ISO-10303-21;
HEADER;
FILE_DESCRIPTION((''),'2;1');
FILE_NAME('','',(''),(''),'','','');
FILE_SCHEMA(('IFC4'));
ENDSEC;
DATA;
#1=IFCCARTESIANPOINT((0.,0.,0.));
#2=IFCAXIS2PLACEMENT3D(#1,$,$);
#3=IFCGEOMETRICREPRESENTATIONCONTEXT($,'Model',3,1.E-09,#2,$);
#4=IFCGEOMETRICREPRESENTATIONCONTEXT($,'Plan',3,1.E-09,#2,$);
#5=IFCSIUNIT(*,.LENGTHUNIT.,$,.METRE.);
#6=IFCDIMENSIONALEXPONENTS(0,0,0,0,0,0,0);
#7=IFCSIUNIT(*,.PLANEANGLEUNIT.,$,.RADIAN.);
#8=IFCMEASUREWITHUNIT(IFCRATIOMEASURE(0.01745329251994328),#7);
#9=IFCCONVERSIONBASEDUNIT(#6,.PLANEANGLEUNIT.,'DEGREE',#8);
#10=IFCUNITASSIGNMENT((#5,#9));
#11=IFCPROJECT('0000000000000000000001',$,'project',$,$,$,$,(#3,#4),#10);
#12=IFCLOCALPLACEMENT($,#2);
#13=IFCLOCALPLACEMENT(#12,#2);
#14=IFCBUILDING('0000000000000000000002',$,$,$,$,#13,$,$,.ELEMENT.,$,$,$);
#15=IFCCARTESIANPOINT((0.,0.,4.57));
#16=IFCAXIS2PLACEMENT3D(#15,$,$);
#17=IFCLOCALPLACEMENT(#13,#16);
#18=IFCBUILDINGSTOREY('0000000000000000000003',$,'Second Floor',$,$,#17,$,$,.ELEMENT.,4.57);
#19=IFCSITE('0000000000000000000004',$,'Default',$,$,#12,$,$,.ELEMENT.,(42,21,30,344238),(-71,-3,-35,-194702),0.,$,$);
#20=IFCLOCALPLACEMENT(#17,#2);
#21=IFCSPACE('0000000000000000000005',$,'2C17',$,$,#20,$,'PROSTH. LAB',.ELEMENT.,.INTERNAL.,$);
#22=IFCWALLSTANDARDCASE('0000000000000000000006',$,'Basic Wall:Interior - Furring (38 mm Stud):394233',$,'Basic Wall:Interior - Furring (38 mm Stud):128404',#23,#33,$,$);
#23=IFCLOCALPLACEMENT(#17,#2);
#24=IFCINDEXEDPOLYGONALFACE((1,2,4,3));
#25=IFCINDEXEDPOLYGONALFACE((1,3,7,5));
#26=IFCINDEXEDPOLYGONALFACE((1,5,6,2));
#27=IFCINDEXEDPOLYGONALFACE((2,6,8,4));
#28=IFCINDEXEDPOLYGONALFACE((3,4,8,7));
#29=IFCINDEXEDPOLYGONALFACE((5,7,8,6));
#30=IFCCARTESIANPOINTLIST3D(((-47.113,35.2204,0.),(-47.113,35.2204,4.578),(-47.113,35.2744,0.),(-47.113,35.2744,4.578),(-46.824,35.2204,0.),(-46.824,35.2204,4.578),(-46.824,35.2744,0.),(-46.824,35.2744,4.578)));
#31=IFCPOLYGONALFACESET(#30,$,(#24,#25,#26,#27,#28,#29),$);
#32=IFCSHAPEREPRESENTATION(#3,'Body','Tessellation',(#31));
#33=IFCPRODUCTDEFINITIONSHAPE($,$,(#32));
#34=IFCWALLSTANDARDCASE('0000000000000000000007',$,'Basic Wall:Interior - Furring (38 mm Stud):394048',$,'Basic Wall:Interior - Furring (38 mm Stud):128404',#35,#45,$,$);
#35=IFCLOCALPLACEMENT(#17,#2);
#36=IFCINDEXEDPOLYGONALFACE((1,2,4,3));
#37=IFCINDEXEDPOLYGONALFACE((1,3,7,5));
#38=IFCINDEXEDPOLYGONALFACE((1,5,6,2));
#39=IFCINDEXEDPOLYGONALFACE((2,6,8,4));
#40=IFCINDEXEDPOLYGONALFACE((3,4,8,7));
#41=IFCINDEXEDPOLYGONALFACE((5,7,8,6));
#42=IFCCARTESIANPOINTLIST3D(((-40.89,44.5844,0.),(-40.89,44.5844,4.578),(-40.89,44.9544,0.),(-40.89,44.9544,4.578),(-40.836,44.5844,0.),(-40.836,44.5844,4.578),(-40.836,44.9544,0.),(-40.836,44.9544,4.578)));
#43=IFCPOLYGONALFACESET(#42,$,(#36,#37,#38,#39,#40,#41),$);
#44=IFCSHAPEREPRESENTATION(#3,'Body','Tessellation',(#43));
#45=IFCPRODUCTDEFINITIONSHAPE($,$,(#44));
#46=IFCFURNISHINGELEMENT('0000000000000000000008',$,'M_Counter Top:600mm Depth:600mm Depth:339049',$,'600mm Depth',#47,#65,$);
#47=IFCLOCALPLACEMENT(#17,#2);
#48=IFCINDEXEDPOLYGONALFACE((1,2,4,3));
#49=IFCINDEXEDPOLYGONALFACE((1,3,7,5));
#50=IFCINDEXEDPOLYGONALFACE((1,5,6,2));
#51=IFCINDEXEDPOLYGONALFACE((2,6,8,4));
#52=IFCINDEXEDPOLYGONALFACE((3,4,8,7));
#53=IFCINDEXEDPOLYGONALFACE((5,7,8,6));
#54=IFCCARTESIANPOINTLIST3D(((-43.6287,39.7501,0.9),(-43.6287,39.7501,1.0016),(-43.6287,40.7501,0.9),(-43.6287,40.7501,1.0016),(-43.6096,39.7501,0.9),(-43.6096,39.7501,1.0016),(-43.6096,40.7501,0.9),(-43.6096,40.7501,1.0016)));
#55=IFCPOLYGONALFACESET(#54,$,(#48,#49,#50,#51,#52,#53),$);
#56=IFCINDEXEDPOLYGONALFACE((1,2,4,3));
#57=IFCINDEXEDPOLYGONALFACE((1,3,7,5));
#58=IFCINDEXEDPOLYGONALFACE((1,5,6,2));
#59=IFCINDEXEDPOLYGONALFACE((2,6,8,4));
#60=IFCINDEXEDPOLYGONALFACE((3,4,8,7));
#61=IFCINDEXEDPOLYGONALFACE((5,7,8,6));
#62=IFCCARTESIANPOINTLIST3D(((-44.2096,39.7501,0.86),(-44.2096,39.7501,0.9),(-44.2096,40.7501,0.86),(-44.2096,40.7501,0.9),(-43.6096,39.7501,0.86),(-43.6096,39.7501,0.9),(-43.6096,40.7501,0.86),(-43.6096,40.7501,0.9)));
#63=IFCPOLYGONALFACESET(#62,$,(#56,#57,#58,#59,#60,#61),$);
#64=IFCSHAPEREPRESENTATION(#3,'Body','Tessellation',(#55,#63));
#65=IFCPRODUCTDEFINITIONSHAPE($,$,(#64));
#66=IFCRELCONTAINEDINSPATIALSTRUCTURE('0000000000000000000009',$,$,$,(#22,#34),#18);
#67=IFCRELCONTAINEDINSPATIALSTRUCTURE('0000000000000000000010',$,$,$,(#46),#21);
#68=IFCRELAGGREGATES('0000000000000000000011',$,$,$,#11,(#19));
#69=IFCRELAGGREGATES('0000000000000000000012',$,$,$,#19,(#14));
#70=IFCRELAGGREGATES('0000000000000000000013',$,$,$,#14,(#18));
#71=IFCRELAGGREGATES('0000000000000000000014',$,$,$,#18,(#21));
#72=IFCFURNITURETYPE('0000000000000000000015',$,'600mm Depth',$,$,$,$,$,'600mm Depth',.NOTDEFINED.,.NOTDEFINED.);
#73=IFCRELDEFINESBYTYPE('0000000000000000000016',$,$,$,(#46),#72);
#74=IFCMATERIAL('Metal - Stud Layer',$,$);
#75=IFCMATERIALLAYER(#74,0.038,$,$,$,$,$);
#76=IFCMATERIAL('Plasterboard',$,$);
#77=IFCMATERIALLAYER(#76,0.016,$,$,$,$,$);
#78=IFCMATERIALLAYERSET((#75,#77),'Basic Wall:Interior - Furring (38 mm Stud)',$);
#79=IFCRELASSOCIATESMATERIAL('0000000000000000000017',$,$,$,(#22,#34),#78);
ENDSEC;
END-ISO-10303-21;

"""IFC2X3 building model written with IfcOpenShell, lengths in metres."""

from ifc_helpers import new_model, entity, si_unit, converted_unit, frame, frame_2d, origin, origin_2d_with_axis, place, context, project, spatial, rectangle, extrude, source, transform, mapped, material, layer, layer_set, layer_usage, type_object, type_shapes, element, save


model = new_model("IFC2X3")

# Units and contexts
model_context = context("Model", 3, precision=1e-09, world=origin())
plan_context = context("Plan", 3, precision=1e-09, world=origin())
ifc_project = project(units=[si_unit("LENGTHUNIT", "METRE"), converted_unit("PLANEANGLEUNIT", "DEGREE", entity("IfcRatioMeasure", 0.01745329251994328), si_unit("PLANEANGLEUNIT", "RADIAN"), dimensions=[0, 0, 0, 0, 0, 0, 0])], contexts=[model_context, plan_context])

# Site, building, storey
site_placement = place(None, origin())
site = spatial("IfcSite", under=ifc_project, at=site_placement, Name="Default", CompositionType="ELEMENT", RefLatitude=(42, 21, 30, 344238), RefLongitude=(-71, -3, -35, -194702), RefElevation=0.0)
building_placement = place(site_placement, origin())
building = spatial("IfcBuilding", under=site, at=building_placement, CompositionType="ELEMENT")
storey_placement = place(building_placement, frame((0.0, 0.0, 4.57)))
storey = spatial("IfcBuildingStorey", under=building, at=storey_placement, Name="Second Floor", CompositionType="ELEMENT", Elevation=4.57)

# Walls
ifc_material_1 = material(Name="Plasterboard")
ifc_material_2 = material(Name="Metal - Stud Layer")
ifc_layer_1 = layer(ifc_material_2, 0.038)
ifc_layer_2 = layer(ifc_material_1, 0.016)
ifc_layer_set_1 = layer_set([ifc_layer_1, ifc_layer_2], Name="Basic Wall:Interior - Furring (38 mm Stud)")
ifc_layer_usage_1 = layer_usage(ifc_layer_set_1, "AXIS2", "NEGATIVE", 0.027)
wall_1_placement = place(storey_placement, frame((-46.824, 35.2474, 0.0), z_axis=(0.0, 0.0, 1.0), x_axis=(-1.0, 0.0, 0.0)))
element("IfcWallStandardCase", 1, at=wall_1_placement, inside=storey, material=ifc_layer_usage_1, Name="Basic Wall:Interior - Furring (38 mm Stud):394233", ObjectType="Basic Wall:Interior - Furring (38 mm Stud):128404", context=model_context, shape_type="SweptSolid", body=[
    extrude(rectangle(XDim=0.289, YDim=0.054, at=frame_2d((0.1445, 0.0), x_axis=(-1.0, 0.0))), origin(), (0.0, 0.0, 1.0), 4.578),
])
wall_2_placement = place(storey_placement, frame((-40.863, 44.9544, 0.0), z_axis=(0.0, 0.0, 1.0), x_axis=(0.0, -1.0, 0.0)))
element("IfcWallStandardCase", 2, at=wall_2_placement, inside=storey, material=ifc_layer_usage_1, Name="Basic Wall:Interior - Furring (38 mm Stud):394048", ObjectType="Basic Wall:Interior - Furring (38 mm Stud):128404", context=model_context, shape_type="SweptSolid", body=[
    extrude(rectangle(XDim=0.37, YDim=0.054, at=frame_2d((0.185, 0.0), x_axis=(-1.0, 0.0))), origin(), (0.0, 0.0, 1.0), 4.578),
])

# Shared definitions
space_placement = place(storey_placement, origin())
space = spatial("IfcSpace", under=storey, at=space_placement, Name="2C17", LongName="PROSTH. LAB", CompositionType="ELEMENT", InteriorOrExteriorSpace="INTERNAL")

# Furnishing element
furniture_type_1 = type_object("IfcFurnitureType", Name="600mm Depth", ElementType="600mm Depth", AssemblyPlace="NOTDEFINED")
shared_shape_1 = source(origin(), model_context, "Body", "SweptSolid", [
    extrude(rectangle(XDim=0.0191, YDim=1.0, at=origin_2d_with_axis()), frame((-0.7005, -0.0095, 0.9), z_axis=(0.0, 0.0, 1.0), x_axis=(0.0, -1.0, 0.0)), (0.0, 0.0, 1.0), 0.1016),
    extrude(rectangle(XDim=1.0, YDim=0.6, at=origin_2d_with_axis()), frame((-0.7005, -0.3, 0.86), z_axis=(0.0, 0.0, 1.0), x_axis=(-1.0, 0.0, 0.0)), (0.0, 0.0, 1.0), 0.04),
])
type_shapes(furniture_type_1, [shared_shape_1])
furnishing_1_placement = place(space_placement, frame((-43.6096, 39.5496, 0.0), z_axis=(0.0, 0.0, 1.0), x_axis=(0.0, -1.0, 0.0)))
element("IfcFurnishingElement", 3, at=furnishing_1_placement, inside=space, type_object=furniture_type_1, Name="M_Counter Top:600mm Depth:600mm Depth:339049", ObjectType="600mm Depth", context=model_context, shape_type="MappedRepresentation", body=[
    mapped(shared_shape_1, transform((0.0, 0.0, 0.0), scale=1.0)),
])

save(model, "model.ifc")
